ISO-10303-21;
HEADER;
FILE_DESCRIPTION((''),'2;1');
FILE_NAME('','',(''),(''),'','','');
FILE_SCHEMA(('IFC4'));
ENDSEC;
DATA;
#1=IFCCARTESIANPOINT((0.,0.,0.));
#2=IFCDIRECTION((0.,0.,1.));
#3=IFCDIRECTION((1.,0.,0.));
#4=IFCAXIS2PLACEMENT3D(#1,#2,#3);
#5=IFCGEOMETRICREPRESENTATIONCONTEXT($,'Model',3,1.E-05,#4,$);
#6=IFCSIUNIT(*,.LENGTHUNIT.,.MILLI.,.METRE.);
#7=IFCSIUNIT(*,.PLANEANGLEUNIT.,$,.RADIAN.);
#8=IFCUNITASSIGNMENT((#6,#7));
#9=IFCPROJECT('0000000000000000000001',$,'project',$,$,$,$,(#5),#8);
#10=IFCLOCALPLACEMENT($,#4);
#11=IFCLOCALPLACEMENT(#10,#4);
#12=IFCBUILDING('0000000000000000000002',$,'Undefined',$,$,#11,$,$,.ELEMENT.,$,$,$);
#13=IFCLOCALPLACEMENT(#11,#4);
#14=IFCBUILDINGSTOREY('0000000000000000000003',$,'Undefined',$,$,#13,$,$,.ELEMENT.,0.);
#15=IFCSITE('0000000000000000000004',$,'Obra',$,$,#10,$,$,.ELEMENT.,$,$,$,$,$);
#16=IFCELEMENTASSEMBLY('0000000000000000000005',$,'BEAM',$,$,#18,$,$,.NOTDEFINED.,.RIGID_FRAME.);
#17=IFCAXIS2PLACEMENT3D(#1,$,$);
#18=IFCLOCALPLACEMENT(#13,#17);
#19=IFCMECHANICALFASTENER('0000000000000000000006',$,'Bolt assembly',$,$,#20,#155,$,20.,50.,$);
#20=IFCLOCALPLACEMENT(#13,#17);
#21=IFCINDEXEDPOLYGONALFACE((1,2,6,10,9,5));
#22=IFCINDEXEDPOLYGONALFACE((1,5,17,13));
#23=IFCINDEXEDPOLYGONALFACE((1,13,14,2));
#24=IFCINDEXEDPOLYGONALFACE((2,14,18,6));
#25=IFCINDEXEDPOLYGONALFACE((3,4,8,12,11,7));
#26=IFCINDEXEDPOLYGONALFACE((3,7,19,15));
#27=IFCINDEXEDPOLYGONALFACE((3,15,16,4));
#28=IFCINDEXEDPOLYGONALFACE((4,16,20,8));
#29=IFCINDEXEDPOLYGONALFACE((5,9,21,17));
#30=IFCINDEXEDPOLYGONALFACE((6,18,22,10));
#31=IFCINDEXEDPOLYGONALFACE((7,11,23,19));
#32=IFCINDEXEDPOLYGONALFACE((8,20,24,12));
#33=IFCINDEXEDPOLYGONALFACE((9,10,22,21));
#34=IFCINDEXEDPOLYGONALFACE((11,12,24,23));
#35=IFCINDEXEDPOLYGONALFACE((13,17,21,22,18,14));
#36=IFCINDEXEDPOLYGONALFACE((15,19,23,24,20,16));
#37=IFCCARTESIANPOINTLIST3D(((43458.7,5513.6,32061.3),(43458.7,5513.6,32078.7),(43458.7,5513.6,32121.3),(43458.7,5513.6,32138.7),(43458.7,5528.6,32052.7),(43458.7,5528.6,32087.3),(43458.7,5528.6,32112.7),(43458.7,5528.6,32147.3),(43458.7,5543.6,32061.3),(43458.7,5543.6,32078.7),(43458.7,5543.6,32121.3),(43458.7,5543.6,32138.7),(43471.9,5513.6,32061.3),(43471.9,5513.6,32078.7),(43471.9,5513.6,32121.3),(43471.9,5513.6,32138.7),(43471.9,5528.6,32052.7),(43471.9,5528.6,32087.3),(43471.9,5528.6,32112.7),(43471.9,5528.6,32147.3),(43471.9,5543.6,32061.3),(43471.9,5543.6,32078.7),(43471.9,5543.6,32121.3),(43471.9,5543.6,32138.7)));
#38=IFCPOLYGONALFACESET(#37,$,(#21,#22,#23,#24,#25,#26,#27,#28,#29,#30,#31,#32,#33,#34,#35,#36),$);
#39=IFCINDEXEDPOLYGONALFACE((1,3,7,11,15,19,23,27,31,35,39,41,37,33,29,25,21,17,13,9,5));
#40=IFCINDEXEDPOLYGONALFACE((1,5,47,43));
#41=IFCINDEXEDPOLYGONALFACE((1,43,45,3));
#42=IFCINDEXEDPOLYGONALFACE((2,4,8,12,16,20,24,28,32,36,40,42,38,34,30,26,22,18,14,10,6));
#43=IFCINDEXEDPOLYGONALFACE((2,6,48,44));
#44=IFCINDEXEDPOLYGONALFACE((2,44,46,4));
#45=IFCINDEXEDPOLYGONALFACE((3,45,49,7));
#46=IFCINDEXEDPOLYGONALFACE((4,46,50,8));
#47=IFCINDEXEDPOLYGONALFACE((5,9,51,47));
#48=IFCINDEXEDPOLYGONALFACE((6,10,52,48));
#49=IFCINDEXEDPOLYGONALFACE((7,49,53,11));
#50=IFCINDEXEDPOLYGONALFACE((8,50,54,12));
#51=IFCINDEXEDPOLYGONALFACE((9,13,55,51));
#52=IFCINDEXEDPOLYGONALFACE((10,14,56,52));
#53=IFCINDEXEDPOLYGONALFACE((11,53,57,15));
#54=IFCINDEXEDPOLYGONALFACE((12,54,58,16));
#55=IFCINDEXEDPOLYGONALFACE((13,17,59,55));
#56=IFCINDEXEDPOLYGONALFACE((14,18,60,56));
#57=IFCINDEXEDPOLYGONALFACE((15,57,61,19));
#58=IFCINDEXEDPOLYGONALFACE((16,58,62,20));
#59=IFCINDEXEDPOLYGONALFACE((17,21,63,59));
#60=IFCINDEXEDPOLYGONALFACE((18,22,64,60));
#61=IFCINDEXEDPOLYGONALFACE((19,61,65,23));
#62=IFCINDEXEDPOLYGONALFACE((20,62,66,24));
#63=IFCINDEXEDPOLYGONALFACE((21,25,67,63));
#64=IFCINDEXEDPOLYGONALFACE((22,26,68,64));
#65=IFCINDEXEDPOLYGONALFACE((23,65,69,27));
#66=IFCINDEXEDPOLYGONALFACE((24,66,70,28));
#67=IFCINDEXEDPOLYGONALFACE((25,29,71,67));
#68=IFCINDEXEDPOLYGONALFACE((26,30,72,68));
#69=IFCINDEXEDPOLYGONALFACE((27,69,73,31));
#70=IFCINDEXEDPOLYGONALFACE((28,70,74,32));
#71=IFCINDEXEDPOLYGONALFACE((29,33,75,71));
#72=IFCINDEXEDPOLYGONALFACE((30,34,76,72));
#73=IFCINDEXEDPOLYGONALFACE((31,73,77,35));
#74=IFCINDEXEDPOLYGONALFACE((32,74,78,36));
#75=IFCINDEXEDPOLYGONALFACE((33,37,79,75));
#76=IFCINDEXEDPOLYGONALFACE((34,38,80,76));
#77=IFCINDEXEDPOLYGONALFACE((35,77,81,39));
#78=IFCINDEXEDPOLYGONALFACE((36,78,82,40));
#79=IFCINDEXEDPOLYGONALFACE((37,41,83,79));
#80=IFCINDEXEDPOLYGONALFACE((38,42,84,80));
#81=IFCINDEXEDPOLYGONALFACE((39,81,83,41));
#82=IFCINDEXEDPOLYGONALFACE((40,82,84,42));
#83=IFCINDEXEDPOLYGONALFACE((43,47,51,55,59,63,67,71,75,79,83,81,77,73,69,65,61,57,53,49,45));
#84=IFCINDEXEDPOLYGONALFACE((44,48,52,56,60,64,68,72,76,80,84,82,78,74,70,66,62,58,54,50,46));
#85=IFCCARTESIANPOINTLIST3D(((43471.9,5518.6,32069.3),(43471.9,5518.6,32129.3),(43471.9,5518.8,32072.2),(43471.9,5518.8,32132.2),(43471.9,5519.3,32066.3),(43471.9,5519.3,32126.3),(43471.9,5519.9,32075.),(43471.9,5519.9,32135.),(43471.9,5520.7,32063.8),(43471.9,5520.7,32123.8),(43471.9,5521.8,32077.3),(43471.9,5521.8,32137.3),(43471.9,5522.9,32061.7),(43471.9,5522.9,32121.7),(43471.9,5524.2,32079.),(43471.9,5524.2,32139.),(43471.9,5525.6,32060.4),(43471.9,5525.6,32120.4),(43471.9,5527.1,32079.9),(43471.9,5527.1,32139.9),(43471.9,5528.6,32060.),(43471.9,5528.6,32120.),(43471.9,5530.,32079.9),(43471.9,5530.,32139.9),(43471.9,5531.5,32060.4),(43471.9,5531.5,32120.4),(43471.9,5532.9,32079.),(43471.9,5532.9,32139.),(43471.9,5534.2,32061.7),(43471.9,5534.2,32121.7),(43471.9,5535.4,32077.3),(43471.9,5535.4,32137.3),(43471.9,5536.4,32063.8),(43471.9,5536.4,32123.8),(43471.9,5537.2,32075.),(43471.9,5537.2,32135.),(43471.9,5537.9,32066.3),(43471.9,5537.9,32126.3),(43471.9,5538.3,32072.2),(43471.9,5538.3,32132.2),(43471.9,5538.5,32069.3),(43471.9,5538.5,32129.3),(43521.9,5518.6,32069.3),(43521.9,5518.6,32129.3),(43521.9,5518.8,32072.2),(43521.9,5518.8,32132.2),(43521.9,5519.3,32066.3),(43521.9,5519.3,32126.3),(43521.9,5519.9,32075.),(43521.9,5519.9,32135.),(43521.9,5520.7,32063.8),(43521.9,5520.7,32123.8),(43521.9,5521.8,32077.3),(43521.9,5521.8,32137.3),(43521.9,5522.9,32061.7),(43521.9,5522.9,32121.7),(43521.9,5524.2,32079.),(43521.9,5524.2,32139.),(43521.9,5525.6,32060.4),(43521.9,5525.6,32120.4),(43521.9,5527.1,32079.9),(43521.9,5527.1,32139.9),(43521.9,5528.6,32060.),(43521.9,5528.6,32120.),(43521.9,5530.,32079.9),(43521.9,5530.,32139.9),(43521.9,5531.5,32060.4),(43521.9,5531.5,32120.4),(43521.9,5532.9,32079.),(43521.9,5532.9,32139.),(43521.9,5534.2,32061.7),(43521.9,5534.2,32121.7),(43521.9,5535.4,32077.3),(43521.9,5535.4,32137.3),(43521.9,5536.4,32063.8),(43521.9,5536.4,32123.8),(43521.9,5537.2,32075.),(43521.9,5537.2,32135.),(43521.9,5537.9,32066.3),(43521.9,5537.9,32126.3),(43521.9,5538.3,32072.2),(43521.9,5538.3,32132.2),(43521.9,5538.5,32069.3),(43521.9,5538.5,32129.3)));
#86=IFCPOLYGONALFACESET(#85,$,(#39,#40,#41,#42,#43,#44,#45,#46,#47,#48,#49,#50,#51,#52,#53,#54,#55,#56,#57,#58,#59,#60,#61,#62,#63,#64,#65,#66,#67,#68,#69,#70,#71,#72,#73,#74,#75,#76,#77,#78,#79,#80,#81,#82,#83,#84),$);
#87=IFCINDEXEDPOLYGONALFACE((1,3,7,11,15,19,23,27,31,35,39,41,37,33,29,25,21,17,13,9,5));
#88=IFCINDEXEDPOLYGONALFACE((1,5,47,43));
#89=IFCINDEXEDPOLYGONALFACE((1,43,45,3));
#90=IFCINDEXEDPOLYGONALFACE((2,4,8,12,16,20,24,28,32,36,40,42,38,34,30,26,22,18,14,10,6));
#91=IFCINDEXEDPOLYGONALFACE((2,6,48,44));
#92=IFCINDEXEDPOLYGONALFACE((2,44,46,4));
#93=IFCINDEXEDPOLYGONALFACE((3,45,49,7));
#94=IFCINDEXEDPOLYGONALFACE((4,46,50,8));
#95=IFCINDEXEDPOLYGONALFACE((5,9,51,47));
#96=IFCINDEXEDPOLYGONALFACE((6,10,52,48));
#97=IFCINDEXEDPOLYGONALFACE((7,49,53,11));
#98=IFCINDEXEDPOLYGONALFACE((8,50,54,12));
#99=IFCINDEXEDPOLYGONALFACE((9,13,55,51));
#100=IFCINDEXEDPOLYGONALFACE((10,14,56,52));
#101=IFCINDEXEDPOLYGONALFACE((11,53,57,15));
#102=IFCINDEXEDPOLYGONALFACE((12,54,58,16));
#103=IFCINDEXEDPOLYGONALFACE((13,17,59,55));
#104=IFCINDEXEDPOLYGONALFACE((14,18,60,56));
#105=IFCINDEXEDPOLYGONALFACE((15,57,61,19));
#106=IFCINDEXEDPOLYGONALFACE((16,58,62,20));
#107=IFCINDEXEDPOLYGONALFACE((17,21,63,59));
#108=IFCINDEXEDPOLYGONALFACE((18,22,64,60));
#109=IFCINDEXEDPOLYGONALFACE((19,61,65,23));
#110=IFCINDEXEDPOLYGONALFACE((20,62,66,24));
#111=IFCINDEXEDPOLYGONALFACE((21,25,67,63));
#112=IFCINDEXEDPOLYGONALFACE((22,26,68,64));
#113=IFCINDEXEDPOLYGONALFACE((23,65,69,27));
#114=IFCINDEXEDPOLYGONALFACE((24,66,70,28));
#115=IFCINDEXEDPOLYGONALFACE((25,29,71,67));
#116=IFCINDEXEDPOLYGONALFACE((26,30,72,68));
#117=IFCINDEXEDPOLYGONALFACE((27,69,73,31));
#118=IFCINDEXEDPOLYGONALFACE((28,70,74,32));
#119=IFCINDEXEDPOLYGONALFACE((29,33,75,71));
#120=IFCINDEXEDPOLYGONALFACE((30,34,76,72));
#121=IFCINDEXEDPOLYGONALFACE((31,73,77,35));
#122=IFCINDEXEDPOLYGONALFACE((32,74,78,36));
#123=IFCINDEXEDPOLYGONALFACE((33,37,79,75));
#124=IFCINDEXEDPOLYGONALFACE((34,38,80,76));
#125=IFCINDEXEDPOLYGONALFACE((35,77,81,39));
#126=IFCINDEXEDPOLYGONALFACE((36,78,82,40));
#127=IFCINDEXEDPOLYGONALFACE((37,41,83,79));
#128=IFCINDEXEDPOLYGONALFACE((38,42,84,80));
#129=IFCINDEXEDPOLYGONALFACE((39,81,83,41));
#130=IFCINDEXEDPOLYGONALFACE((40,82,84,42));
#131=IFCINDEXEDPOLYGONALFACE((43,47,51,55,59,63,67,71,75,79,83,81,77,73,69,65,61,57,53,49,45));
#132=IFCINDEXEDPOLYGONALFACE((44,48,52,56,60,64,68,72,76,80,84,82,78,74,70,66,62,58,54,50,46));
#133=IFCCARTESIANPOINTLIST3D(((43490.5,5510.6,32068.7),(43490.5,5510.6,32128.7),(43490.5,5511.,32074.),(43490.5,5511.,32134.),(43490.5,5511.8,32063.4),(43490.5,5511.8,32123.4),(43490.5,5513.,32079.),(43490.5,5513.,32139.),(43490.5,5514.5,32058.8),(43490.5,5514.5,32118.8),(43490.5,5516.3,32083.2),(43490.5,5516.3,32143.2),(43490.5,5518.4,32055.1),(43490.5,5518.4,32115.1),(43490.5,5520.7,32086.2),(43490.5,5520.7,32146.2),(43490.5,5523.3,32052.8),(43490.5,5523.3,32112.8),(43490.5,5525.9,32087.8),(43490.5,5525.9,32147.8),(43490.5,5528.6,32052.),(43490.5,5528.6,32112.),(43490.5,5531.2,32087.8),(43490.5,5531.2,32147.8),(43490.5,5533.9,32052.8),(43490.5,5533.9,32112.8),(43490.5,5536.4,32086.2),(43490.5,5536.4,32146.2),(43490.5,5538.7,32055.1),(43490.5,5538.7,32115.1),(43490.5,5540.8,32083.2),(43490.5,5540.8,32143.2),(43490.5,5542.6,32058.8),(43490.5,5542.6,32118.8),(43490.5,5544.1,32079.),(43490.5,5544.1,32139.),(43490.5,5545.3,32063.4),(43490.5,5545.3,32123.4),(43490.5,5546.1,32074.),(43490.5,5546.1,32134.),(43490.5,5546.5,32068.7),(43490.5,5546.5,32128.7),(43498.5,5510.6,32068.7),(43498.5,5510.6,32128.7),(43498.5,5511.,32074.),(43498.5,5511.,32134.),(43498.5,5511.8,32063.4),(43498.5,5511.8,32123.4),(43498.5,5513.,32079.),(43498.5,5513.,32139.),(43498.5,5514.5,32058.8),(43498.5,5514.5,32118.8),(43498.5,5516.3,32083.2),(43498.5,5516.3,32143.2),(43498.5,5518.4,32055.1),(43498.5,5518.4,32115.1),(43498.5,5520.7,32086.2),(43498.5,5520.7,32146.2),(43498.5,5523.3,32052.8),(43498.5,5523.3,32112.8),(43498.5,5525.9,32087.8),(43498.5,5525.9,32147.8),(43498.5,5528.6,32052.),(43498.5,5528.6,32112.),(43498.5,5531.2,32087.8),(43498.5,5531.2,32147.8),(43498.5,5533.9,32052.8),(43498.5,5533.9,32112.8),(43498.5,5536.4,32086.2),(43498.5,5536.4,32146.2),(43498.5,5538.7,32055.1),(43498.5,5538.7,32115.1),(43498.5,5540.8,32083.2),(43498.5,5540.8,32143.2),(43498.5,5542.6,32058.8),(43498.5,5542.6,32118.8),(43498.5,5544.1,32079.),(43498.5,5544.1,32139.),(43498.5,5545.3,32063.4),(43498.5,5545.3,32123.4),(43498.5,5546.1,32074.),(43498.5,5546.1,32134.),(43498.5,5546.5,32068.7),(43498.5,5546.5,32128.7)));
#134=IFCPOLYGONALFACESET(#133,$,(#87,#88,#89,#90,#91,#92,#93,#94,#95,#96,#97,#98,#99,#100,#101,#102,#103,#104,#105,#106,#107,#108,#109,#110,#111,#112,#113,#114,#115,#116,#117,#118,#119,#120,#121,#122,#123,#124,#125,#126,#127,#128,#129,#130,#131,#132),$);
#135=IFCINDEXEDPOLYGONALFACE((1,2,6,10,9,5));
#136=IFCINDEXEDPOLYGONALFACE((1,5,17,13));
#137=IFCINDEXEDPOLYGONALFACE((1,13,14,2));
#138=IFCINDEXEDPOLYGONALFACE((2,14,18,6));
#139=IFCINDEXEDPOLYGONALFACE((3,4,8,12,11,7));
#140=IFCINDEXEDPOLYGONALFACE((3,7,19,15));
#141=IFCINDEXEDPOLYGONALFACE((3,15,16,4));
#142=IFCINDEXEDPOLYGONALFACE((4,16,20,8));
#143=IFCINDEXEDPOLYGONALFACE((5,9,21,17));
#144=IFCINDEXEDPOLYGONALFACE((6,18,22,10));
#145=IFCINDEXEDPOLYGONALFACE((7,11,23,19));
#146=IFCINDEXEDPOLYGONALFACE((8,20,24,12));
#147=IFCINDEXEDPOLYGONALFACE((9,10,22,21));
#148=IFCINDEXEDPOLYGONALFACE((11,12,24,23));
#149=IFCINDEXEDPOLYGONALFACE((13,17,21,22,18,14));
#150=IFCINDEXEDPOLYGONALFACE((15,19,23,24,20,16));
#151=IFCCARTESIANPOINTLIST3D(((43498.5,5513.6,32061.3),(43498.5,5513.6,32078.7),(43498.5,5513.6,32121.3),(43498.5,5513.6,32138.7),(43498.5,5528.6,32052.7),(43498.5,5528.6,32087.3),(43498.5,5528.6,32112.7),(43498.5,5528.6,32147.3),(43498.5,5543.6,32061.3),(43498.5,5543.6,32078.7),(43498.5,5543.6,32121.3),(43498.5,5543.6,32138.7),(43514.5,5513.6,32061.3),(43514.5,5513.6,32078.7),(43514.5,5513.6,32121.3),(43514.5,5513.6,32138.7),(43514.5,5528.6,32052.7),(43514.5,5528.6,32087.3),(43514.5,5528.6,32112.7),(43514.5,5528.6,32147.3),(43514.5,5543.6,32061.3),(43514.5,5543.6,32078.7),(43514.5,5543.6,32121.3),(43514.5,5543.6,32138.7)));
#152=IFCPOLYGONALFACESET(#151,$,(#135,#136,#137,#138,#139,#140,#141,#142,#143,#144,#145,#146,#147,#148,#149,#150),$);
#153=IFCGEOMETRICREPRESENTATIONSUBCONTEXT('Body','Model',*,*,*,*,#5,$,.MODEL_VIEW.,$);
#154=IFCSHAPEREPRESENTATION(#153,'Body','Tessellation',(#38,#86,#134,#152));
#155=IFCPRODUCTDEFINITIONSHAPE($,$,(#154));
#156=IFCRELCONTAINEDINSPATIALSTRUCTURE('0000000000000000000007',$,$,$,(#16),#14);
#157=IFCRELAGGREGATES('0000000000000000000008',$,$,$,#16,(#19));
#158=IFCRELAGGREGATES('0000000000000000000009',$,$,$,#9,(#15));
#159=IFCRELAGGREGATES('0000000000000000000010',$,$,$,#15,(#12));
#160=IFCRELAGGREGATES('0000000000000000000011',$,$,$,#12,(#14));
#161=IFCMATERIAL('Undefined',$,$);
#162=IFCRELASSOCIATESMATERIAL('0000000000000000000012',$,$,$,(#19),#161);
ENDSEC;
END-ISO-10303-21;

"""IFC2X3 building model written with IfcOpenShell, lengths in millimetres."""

from ifc_helpers import new_model, si_unit, frame, origin_with_axes, origin_2d_with_axis, place, context, subcontext, project, spatial, polyline, circle, outline, extrude, source, transform, mapped, material, element, aggregate, save


model = new_model("IFC2X3")

# Units and contexts
model_context = context("Model", 3, precision=1e-05, world=origin_with_axes())
body_context = subcontext(model_context, "Body", "Model", "MODEL_VIEW")
ifc_project = project(units=[si_unit("LENGTHUNIT", "METRE", prefix="MILLI"), si_unit("PLANEANGLEUNIT", "RADIAN")], contexts=[model_context])

# Site, building, storey
site_placement = place(None, origin_with_axes())
site = spatial("IfcSite", under=ifc_project, at=site_placement, Name="Obra", CompositionType="ELEMENT")
building_placement = place(site_placement, origin_with_axes())
building = spatial("IfcBuilding", under=site, at=building_placement, Name="Undefined", CompositionType="ELEMENT")
storey_placement = place(building_placement, origin_with_axes())
storey = spatial("IfcBuildingStorey", under=building, at=storey_placement, Name="Undefined", CompositionType="ELEMENT", Elevation=0.0)

# Element assembly, mechanical fastener
assembly_1_placement = place(storey_placement, origin_with_axes())
assembly_1 = element("IfcElementAssembly", 1, at=assembly_1_placement, inside=storey, Name="BEAM", AssemblyPlace="NOTDEFINED", PredefinedType="RIGID_FRAME")
ifc_material_1 = material(Name="Undefined")
shared_shape_1 = source(origin_with_axes(), body_context, "Body", "SweptSolid", [
    extrude(outline(polyline([(17.3, 0.0), (8.7, 15.0), (-8.7, 15.0), (-17.3, 0.0), (-8.7, -15.0), (8.7, -15.0), (17.3, 0.0)])), frame((0.0, -27.5, 0.0), z_axis=(0.0, 1.0, 0.0), x_axis=(1.0, 0.0, 0.0)), (0.0, 0.0, 1.0), 13.2),
    extrude(circle(Radius=10.0, at=origin_2d_with_axis()), frame((0.0, -14.3, 0.0), z_axis=(0.0, 1.0, 0.0), x_axis=(1.0, 0.0, 0.0)), (0.0, 0.0, 1.0), 50.0),
    extrude(circle(Radius=18.0, at=origin_2d_with_axis()), frame((0.0, 4.3, 0.0), z_axis=(0.0, 1.0, 0.0), x_axis=(1.0, 0.0, 0.0)), (0.0, 0.0, 1.0), 8.0),
    extrude(outline(polyline([(17.3, 0.0), (8.7, 15.0), (-8.7, 15.0), (-17.3, 0.0), (-8.7, -15.0), (8.7, -15.0), (17.3, 0.0)])), frame((0.0, 12.3, 0.0), z_axis=(0.0, 1.0, 0.0), x_axis=(1.0, 0.0, 0.0)), (0.0, 0.0, 1.0), 16.0),
])
mechanical_fastener_1_placement = place(assembly_1_placement, frame((43486.2, 5568.6, 32170.0), z_axis=(0.0, -1.0, 0.0), x_axis=(0.0, 0.0, -1.0)))
mechanical_fastener_1 = element("IfcMechanicalFastener", 2, at=mechanical_fastener_1_placement, material=ifc_material_1, Name="Bolt assembly", NominalDiameter=20.0, NominalLength=50.0, context=body_context, shape_type="MappedRepresentation", body=[
    mapped(shared_shape_1, transform((40.0, 0.0, 40.0))),
    mapped(shared_shape_1, transform((100.0, 0.0, 40.0))),
])
aggregate(assembly_1, [mechanical_fastener_1])

save(model, "model.ifc")
